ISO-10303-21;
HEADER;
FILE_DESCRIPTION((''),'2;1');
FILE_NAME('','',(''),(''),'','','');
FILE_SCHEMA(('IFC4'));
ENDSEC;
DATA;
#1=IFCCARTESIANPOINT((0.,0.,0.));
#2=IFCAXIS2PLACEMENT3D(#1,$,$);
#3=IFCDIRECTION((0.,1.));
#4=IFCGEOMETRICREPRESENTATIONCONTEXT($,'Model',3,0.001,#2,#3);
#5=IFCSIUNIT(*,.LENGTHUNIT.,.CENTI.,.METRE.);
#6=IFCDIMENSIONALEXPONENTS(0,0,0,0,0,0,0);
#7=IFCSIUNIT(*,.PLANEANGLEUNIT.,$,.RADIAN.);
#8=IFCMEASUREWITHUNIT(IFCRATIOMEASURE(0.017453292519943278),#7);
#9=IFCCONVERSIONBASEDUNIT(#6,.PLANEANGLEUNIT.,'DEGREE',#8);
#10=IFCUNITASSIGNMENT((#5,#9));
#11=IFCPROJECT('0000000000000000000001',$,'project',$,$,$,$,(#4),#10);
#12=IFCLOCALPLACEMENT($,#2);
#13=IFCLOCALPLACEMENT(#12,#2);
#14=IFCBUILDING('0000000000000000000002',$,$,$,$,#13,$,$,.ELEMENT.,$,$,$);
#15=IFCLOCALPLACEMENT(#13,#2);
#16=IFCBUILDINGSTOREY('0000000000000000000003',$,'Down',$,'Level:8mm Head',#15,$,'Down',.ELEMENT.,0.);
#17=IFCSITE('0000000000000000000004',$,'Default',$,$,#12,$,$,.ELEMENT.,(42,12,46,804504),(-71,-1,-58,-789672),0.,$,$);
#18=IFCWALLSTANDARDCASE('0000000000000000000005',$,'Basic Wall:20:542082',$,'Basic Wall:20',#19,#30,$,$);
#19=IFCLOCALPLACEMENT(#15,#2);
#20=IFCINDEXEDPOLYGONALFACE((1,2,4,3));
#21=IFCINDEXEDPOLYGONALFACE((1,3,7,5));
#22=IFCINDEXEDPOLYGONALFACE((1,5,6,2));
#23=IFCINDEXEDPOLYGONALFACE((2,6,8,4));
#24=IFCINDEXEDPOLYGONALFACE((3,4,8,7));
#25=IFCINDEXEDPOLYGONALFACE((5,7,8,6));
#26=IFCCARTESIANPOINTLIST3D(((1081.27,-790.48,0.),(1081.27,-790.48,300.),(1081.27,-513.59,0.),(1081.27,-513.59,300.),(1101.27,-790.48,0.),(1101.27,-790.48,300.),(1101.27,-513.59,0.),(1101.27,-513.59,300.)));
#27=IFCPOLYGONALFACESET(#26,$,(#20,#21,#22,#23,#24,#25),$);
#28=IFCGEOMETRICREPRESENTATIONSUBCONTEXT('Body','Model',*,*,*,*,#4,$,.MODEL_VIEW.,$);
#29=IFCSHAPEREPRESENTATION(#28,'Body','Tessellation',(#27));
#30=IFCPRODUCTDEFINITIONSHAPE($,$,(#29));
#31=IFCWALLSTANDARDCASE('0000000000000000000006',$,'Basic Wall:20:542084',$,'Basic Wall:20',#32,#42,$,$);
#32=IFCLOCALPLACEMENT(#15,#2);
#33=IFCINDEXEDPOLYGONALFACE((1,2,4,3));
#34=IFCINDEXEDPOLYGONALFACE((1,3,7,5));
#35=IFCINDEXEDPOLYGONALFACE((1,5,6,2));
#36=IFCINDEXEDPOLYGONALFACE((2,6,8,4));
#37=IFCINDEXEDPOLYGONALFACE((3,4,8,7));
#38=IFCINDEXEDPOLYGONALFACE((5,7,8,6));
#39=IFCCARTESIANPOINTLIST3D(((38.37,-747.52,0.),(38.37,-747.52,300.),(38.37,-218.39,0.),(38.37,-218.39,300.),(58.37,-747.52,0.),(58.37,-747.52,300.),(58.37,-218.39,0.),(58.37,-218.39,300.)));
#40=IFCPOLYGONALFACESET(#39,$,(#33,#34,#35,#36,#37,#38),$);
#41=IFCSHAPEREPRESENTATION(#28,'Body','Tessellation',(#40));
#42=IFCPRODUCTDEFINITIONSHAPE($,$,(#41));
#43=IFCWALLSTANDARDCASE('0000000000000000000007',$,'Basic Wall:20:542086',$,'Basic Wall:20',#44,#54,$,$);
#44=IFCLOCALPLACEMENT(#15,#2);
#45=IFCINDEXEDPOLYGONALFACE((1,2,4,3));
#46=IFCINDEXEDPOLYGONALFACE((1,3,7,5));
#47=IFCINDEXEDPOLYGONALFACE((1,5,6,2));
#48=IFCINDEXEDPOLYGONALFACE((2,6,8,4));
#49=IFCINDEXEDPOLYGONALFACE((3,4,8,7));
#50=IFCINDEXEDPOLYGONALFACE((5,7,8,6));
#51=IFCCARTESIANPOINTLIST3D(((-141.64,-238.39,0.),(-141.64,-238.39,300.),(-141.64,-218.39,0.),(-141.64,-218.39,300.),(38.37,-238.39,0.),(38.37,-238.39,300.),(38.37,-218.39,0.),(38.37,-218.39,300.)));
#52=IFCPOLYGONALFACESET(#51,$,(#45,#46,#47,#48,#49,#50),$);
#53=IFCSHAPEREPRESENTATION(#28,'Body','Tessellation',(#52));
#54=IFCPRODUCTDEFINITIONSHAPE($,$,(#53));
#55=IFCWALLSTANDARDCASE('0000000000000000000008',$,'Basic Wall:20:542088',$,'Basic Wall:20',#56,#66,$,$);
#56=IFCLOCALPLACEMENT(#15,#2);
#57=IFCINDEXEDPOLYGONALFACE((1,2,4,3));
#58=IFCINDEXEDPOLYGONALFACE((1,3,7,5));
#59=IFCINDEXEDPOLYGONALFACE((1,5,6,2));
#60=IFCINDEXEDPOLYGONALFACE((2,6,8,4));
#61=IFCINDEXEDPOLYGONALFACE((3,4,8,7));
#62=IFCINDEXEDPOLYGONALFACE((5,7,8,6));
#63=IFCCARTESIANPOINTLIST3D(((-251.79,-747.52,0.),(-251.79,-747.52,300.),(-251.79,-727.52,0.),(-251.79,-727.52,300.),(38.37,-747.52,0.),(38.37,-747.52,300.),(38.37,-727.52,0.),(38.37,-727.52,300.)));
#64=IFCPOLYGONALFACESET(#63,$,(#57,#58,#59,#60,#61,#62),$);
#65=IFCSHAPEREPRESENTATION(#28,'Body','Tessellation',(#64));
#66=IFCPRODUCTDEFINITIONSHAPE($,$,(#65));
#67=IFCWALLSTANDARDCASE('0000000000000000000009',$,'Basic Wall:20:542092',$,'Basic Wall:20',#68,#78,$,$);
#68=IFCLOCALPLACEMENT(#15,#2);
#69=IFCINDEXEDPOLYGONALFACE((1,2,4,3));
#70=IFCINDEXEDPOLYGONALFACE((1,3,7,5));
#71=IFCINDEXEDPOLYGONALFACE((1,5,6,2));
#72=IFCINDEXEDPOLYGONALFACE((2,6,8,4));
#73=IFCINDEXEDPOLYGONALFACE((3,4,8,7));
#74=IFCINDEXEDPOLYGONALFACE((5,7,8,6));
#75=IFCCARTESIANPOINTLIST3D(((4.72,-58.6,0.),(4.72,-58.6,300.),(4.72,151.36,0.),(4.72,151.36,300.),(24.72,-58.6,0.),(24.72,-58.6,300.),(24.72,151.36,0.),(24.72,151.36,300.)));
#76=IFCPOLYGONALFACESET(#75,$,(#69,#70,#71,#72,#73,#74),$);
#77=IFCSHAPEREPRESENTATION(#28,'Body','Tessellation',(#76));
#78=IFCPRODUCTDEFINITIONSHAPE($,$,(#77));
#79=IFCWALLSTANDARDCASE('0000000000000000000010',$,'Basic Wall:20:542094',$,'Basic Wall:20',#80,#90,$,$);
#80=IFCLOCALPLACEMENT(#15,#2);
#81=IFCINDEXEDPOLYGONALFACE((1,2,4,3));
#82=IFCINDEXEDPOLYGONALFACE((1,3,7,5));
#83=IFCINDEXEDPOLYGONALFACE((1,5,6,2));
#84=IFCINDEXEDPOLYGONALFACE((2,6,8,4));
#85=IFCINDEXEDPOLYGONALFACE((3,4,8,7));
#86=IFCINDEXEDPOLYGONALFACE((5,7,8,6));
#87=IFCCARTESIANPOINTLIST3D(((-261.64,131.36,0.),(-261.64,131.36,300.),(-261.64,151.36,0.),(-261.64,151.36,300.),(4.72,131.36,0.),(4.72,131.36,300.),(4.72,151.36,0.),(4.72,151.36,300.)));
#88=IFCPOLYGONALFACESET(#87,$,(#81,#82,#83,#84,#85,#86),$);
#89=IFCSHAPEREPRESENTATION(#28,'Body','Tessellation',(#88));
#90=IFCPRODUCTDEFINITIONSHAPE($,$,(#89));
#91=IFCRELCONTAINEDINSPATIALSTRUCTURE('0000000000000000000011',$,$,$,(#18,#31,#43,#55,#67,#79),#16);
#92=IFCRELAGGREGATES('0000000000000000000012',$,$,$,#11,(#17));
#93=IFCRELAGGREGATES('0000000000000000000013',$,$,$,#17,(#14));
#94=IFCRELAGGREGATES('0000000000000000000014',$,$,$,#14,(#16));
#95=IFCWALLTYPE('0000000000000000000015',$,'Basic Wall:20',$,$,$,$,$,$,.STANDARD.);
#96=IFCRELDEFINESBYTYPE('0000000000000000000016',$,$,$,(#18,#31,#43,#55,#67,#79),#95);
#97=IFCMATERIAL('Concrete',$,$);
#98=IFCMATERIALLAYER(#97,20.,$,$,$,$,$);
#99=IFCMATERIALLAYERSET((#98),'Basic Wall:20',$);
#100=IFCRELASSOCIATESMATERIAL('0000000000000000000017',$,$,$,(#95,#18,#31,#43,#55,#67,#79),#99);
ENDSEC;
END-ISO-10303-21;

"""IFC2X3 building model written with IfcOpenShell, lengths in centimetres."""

from ifc_helpers import new_model, entity, si_unit, converted_unit, direction, frame, frame_2d, origin, place, context, subcontext, project, spatial, rectangle, extrude, material, layer, layer_set, layer_usage, type_object, element, save


model = new_model("IFC2X3")

# Units and contexts
model_context = context("Model", 3, precision=0.001, world=origin(), true_north=direction((0.0, 1.0)))
body_context = subcontext(model_context, "Body", "Model", "MODEL_VIEW")
ifc_project = project(units=[si_unit("LENGTHUNIT", "METRE", prefix="CENTI"), converted_unit("PLANEANGLEUNIT", "DEGREE", entity("IfcRatioMeasure", 0.017453292519943278), si_unit("PLANEANGLEUNIT", "RADIAN"), dimensions=[0, 0, 0, 0, 0, 0, 0])], contexts=[model_context])

# Site, building, storey
site_placement = place(None, origin())
site = spatial("IfcSite", under=ifc_project, at=site_placement, Name="Default", CompositionType="ELEMENT", RefLatitude=(42, 12, 46, 804504), RefLongitude=(-71, -1, -58, -789672), RefElevation=0.0)
building_placement = place(site_placement, origin())
building = spatial("IfcBuilding", under=site, at=building_placement, CompositionType="ELEMENT")
storey_placement = place(building_placement, origin())
storey = spatial("IfcBuildingStorey", under=building, at=storey_placement, Name="Down", ObjectType="Level:8mm Head", LongName="Down", CompositionType="ELEMENT", Elevation=0.0)

# Shared definitions
ifc_material = material(Name="Concrete")

# Walls
ifc_layer_1 = layer(ifc_material, 20.0)
ifc_layer_set_1 = layer_set([ifc_layer_1], Name="Basic Wall:20")
wall_type_1 = type_object("IfcWallType", Name="Basic Wall:20", PredefinedType="STANDARD", material=ifc_layer_set_1)
ifc_layer_usage_1 = layer_usage(ifc_layer_set_1, "AXIS2", "NEGATIVE", 10.0)
wall_1_placement = place(storey_placement, frame((1091.27, -790.48, 0.0), z_axis=(0.0, 0.0, 1.0), x_axis=(0.0, 1.0, 0.0)))
element("IfcWallStandardCase", 1, at=wall_1_placement, inside=storey, type_object=wall_type_1, material=ifc_layer_usage_1, Name="Basic Wall:20:542082", ObjectType="Basic Wall:20", context=body_context, shape_type="SweptSolid", body=[
    extrude(rectangle(XDim=276.89, YDim=20.0, at=frame_2d((138.45, 0.0), x_axis=(-1.0, 0.0))), origin(), (0.0, 0.0, 1.0), 300.0),
])
ifc_layer_usage_2 = layer_usage(ifc_layer_set_1, "AXIS2", "NEGATIVE", 10.0)
wall_2_placement = place(storey_placement, frame((48.37, -218.39, 0.0), z_axis=(0.0, 0.0, 1.0), x_axis=(0.0, -1.0, 0.0)))
element("IfcWallStandardCase", 2, at=wall_2_placement, inside=storey, type_object=wall_type_1, material=ifc_layer_usage_2, Name="Basic Wall:20:542084", ObjectType="Basic Wall:20", context=body_context, shape_type="SweptSolid", body=[
    extrude(rectangle(XDim=529.12, YDim=20.0, at=frame_2d((264.56, 0.0), x_axis=(-1.0, 0.0))), origin(), (0.0, 0.0, 1.0), 300.0),
])
ifc_layer_usage_3 = layer_usage(ifc_layer_set_1, "AXIS2", "POSITIVE", -10.0)
wall_3_placement = place(storey_placement, frame((38.37, -228.39, 0.0), z_axis=(0.0, 0.0, 1.0), x_axis=(-1.0, 0.0, 0.0)))
element("IfcWallStandardCase", 3, at=wall_3_placement, inside=storey, type_object=wall_type_1, material=ifc_layer_usage_3, Name="Basic Wall:20:542086", ObjectType="Basic Wall:20", context=body_context, shape_type="SweptSolid", body=[
    extrude(rectangle(XDim=180.01, YDim=20.0, at=frame_2d((90.0, 0.0), x_axis=(-1.0, 0.0))), origin(), (0.0, 0.0, 1.0), 300.0),
])
ifc_layer_usage_4 = layer_usage(ifc_layer_set_1, "AXIS2", "NEGATIVE", 10.0)
wall_4_placement = place(storey_placement, frame((38.37, -737.52, 0.0), z_axis=(0.0, 0.0, 1.0), x_axis=(-1.0, 0.0, 0.0)))
element("IfcWallStandardCase", 4, at=wall_4_placement, inside=storey, type_object=wall_type_1, material=ifc_layer_usage_4, Name="Basic Wall:20:542088", ObjectType="Basic Wall:20", context=body_context, shape_type="SweptSolid", body=[
    extrude(rectangle(XDim=290.17, YDim=20.0, at=frame_2d((145.08, 0.0), x_axis=(-1.0, 0.0))), origin(), (0.0, 0.0, 1.0), 300.0),
])
ifc_layer_usage_5 = layer_usage(ifc_layer_set_1, "AXIS2", "POSITIVE", -10.0)
wall_5_placement = place(storey_placement, frame((14.72, -58.6, 0.0), z_axis=(0.0, 0.0, 1.0), x_axis=(0.0, 1.0, 0.0)))
element("IfcWallStandardCase", 5, at=wall_5_placement, inside=storey, type_object=wall_type_1, material=ifc_layer_usage_5, Name="Basic Wall:20:542092", ObjectType="Basic Wall:20", context=body_context, shape_type="SweptSolid", body=[
    extrude(rectangle(XDim=209.96, YDim=20.0, at=frame_2d((104.98, 0.0), x_axis=(-1.0, 0.0))), origin(), (0.0, 0.0, 1.0), 300.0),
])
ifc_layer_usage_6 = layer_usage(ifc_layer_set_1, "AXIS2", "POSITIVE", -10.0)
wall_6_placement = place(storey_placement, frame((4.72, 141.36, 0.0), z_axis=(0.0, 0.0, 1.0), x_axis=(-1.0, 0.0, 0.0)))
element("IfcWallStandardCase", 6, at=wall_6_placement, inside=storey, type_object=wall_type_1, material=ifc_layer_usage_6, Name="Basic Wall:20:542094", ObjectType="Basic Wall:20", context=body_context, shape_type="SweptSolid", body=[
    extrude(rectangle(XDim=266.35, YDim=20.0, at=frame_2d((133.18, 0.0), x_axis=(-1.0, 0.0))), origin(), (0.0, 0.0, 1.0), 300.0),
])

save(model, "model.ifc")
